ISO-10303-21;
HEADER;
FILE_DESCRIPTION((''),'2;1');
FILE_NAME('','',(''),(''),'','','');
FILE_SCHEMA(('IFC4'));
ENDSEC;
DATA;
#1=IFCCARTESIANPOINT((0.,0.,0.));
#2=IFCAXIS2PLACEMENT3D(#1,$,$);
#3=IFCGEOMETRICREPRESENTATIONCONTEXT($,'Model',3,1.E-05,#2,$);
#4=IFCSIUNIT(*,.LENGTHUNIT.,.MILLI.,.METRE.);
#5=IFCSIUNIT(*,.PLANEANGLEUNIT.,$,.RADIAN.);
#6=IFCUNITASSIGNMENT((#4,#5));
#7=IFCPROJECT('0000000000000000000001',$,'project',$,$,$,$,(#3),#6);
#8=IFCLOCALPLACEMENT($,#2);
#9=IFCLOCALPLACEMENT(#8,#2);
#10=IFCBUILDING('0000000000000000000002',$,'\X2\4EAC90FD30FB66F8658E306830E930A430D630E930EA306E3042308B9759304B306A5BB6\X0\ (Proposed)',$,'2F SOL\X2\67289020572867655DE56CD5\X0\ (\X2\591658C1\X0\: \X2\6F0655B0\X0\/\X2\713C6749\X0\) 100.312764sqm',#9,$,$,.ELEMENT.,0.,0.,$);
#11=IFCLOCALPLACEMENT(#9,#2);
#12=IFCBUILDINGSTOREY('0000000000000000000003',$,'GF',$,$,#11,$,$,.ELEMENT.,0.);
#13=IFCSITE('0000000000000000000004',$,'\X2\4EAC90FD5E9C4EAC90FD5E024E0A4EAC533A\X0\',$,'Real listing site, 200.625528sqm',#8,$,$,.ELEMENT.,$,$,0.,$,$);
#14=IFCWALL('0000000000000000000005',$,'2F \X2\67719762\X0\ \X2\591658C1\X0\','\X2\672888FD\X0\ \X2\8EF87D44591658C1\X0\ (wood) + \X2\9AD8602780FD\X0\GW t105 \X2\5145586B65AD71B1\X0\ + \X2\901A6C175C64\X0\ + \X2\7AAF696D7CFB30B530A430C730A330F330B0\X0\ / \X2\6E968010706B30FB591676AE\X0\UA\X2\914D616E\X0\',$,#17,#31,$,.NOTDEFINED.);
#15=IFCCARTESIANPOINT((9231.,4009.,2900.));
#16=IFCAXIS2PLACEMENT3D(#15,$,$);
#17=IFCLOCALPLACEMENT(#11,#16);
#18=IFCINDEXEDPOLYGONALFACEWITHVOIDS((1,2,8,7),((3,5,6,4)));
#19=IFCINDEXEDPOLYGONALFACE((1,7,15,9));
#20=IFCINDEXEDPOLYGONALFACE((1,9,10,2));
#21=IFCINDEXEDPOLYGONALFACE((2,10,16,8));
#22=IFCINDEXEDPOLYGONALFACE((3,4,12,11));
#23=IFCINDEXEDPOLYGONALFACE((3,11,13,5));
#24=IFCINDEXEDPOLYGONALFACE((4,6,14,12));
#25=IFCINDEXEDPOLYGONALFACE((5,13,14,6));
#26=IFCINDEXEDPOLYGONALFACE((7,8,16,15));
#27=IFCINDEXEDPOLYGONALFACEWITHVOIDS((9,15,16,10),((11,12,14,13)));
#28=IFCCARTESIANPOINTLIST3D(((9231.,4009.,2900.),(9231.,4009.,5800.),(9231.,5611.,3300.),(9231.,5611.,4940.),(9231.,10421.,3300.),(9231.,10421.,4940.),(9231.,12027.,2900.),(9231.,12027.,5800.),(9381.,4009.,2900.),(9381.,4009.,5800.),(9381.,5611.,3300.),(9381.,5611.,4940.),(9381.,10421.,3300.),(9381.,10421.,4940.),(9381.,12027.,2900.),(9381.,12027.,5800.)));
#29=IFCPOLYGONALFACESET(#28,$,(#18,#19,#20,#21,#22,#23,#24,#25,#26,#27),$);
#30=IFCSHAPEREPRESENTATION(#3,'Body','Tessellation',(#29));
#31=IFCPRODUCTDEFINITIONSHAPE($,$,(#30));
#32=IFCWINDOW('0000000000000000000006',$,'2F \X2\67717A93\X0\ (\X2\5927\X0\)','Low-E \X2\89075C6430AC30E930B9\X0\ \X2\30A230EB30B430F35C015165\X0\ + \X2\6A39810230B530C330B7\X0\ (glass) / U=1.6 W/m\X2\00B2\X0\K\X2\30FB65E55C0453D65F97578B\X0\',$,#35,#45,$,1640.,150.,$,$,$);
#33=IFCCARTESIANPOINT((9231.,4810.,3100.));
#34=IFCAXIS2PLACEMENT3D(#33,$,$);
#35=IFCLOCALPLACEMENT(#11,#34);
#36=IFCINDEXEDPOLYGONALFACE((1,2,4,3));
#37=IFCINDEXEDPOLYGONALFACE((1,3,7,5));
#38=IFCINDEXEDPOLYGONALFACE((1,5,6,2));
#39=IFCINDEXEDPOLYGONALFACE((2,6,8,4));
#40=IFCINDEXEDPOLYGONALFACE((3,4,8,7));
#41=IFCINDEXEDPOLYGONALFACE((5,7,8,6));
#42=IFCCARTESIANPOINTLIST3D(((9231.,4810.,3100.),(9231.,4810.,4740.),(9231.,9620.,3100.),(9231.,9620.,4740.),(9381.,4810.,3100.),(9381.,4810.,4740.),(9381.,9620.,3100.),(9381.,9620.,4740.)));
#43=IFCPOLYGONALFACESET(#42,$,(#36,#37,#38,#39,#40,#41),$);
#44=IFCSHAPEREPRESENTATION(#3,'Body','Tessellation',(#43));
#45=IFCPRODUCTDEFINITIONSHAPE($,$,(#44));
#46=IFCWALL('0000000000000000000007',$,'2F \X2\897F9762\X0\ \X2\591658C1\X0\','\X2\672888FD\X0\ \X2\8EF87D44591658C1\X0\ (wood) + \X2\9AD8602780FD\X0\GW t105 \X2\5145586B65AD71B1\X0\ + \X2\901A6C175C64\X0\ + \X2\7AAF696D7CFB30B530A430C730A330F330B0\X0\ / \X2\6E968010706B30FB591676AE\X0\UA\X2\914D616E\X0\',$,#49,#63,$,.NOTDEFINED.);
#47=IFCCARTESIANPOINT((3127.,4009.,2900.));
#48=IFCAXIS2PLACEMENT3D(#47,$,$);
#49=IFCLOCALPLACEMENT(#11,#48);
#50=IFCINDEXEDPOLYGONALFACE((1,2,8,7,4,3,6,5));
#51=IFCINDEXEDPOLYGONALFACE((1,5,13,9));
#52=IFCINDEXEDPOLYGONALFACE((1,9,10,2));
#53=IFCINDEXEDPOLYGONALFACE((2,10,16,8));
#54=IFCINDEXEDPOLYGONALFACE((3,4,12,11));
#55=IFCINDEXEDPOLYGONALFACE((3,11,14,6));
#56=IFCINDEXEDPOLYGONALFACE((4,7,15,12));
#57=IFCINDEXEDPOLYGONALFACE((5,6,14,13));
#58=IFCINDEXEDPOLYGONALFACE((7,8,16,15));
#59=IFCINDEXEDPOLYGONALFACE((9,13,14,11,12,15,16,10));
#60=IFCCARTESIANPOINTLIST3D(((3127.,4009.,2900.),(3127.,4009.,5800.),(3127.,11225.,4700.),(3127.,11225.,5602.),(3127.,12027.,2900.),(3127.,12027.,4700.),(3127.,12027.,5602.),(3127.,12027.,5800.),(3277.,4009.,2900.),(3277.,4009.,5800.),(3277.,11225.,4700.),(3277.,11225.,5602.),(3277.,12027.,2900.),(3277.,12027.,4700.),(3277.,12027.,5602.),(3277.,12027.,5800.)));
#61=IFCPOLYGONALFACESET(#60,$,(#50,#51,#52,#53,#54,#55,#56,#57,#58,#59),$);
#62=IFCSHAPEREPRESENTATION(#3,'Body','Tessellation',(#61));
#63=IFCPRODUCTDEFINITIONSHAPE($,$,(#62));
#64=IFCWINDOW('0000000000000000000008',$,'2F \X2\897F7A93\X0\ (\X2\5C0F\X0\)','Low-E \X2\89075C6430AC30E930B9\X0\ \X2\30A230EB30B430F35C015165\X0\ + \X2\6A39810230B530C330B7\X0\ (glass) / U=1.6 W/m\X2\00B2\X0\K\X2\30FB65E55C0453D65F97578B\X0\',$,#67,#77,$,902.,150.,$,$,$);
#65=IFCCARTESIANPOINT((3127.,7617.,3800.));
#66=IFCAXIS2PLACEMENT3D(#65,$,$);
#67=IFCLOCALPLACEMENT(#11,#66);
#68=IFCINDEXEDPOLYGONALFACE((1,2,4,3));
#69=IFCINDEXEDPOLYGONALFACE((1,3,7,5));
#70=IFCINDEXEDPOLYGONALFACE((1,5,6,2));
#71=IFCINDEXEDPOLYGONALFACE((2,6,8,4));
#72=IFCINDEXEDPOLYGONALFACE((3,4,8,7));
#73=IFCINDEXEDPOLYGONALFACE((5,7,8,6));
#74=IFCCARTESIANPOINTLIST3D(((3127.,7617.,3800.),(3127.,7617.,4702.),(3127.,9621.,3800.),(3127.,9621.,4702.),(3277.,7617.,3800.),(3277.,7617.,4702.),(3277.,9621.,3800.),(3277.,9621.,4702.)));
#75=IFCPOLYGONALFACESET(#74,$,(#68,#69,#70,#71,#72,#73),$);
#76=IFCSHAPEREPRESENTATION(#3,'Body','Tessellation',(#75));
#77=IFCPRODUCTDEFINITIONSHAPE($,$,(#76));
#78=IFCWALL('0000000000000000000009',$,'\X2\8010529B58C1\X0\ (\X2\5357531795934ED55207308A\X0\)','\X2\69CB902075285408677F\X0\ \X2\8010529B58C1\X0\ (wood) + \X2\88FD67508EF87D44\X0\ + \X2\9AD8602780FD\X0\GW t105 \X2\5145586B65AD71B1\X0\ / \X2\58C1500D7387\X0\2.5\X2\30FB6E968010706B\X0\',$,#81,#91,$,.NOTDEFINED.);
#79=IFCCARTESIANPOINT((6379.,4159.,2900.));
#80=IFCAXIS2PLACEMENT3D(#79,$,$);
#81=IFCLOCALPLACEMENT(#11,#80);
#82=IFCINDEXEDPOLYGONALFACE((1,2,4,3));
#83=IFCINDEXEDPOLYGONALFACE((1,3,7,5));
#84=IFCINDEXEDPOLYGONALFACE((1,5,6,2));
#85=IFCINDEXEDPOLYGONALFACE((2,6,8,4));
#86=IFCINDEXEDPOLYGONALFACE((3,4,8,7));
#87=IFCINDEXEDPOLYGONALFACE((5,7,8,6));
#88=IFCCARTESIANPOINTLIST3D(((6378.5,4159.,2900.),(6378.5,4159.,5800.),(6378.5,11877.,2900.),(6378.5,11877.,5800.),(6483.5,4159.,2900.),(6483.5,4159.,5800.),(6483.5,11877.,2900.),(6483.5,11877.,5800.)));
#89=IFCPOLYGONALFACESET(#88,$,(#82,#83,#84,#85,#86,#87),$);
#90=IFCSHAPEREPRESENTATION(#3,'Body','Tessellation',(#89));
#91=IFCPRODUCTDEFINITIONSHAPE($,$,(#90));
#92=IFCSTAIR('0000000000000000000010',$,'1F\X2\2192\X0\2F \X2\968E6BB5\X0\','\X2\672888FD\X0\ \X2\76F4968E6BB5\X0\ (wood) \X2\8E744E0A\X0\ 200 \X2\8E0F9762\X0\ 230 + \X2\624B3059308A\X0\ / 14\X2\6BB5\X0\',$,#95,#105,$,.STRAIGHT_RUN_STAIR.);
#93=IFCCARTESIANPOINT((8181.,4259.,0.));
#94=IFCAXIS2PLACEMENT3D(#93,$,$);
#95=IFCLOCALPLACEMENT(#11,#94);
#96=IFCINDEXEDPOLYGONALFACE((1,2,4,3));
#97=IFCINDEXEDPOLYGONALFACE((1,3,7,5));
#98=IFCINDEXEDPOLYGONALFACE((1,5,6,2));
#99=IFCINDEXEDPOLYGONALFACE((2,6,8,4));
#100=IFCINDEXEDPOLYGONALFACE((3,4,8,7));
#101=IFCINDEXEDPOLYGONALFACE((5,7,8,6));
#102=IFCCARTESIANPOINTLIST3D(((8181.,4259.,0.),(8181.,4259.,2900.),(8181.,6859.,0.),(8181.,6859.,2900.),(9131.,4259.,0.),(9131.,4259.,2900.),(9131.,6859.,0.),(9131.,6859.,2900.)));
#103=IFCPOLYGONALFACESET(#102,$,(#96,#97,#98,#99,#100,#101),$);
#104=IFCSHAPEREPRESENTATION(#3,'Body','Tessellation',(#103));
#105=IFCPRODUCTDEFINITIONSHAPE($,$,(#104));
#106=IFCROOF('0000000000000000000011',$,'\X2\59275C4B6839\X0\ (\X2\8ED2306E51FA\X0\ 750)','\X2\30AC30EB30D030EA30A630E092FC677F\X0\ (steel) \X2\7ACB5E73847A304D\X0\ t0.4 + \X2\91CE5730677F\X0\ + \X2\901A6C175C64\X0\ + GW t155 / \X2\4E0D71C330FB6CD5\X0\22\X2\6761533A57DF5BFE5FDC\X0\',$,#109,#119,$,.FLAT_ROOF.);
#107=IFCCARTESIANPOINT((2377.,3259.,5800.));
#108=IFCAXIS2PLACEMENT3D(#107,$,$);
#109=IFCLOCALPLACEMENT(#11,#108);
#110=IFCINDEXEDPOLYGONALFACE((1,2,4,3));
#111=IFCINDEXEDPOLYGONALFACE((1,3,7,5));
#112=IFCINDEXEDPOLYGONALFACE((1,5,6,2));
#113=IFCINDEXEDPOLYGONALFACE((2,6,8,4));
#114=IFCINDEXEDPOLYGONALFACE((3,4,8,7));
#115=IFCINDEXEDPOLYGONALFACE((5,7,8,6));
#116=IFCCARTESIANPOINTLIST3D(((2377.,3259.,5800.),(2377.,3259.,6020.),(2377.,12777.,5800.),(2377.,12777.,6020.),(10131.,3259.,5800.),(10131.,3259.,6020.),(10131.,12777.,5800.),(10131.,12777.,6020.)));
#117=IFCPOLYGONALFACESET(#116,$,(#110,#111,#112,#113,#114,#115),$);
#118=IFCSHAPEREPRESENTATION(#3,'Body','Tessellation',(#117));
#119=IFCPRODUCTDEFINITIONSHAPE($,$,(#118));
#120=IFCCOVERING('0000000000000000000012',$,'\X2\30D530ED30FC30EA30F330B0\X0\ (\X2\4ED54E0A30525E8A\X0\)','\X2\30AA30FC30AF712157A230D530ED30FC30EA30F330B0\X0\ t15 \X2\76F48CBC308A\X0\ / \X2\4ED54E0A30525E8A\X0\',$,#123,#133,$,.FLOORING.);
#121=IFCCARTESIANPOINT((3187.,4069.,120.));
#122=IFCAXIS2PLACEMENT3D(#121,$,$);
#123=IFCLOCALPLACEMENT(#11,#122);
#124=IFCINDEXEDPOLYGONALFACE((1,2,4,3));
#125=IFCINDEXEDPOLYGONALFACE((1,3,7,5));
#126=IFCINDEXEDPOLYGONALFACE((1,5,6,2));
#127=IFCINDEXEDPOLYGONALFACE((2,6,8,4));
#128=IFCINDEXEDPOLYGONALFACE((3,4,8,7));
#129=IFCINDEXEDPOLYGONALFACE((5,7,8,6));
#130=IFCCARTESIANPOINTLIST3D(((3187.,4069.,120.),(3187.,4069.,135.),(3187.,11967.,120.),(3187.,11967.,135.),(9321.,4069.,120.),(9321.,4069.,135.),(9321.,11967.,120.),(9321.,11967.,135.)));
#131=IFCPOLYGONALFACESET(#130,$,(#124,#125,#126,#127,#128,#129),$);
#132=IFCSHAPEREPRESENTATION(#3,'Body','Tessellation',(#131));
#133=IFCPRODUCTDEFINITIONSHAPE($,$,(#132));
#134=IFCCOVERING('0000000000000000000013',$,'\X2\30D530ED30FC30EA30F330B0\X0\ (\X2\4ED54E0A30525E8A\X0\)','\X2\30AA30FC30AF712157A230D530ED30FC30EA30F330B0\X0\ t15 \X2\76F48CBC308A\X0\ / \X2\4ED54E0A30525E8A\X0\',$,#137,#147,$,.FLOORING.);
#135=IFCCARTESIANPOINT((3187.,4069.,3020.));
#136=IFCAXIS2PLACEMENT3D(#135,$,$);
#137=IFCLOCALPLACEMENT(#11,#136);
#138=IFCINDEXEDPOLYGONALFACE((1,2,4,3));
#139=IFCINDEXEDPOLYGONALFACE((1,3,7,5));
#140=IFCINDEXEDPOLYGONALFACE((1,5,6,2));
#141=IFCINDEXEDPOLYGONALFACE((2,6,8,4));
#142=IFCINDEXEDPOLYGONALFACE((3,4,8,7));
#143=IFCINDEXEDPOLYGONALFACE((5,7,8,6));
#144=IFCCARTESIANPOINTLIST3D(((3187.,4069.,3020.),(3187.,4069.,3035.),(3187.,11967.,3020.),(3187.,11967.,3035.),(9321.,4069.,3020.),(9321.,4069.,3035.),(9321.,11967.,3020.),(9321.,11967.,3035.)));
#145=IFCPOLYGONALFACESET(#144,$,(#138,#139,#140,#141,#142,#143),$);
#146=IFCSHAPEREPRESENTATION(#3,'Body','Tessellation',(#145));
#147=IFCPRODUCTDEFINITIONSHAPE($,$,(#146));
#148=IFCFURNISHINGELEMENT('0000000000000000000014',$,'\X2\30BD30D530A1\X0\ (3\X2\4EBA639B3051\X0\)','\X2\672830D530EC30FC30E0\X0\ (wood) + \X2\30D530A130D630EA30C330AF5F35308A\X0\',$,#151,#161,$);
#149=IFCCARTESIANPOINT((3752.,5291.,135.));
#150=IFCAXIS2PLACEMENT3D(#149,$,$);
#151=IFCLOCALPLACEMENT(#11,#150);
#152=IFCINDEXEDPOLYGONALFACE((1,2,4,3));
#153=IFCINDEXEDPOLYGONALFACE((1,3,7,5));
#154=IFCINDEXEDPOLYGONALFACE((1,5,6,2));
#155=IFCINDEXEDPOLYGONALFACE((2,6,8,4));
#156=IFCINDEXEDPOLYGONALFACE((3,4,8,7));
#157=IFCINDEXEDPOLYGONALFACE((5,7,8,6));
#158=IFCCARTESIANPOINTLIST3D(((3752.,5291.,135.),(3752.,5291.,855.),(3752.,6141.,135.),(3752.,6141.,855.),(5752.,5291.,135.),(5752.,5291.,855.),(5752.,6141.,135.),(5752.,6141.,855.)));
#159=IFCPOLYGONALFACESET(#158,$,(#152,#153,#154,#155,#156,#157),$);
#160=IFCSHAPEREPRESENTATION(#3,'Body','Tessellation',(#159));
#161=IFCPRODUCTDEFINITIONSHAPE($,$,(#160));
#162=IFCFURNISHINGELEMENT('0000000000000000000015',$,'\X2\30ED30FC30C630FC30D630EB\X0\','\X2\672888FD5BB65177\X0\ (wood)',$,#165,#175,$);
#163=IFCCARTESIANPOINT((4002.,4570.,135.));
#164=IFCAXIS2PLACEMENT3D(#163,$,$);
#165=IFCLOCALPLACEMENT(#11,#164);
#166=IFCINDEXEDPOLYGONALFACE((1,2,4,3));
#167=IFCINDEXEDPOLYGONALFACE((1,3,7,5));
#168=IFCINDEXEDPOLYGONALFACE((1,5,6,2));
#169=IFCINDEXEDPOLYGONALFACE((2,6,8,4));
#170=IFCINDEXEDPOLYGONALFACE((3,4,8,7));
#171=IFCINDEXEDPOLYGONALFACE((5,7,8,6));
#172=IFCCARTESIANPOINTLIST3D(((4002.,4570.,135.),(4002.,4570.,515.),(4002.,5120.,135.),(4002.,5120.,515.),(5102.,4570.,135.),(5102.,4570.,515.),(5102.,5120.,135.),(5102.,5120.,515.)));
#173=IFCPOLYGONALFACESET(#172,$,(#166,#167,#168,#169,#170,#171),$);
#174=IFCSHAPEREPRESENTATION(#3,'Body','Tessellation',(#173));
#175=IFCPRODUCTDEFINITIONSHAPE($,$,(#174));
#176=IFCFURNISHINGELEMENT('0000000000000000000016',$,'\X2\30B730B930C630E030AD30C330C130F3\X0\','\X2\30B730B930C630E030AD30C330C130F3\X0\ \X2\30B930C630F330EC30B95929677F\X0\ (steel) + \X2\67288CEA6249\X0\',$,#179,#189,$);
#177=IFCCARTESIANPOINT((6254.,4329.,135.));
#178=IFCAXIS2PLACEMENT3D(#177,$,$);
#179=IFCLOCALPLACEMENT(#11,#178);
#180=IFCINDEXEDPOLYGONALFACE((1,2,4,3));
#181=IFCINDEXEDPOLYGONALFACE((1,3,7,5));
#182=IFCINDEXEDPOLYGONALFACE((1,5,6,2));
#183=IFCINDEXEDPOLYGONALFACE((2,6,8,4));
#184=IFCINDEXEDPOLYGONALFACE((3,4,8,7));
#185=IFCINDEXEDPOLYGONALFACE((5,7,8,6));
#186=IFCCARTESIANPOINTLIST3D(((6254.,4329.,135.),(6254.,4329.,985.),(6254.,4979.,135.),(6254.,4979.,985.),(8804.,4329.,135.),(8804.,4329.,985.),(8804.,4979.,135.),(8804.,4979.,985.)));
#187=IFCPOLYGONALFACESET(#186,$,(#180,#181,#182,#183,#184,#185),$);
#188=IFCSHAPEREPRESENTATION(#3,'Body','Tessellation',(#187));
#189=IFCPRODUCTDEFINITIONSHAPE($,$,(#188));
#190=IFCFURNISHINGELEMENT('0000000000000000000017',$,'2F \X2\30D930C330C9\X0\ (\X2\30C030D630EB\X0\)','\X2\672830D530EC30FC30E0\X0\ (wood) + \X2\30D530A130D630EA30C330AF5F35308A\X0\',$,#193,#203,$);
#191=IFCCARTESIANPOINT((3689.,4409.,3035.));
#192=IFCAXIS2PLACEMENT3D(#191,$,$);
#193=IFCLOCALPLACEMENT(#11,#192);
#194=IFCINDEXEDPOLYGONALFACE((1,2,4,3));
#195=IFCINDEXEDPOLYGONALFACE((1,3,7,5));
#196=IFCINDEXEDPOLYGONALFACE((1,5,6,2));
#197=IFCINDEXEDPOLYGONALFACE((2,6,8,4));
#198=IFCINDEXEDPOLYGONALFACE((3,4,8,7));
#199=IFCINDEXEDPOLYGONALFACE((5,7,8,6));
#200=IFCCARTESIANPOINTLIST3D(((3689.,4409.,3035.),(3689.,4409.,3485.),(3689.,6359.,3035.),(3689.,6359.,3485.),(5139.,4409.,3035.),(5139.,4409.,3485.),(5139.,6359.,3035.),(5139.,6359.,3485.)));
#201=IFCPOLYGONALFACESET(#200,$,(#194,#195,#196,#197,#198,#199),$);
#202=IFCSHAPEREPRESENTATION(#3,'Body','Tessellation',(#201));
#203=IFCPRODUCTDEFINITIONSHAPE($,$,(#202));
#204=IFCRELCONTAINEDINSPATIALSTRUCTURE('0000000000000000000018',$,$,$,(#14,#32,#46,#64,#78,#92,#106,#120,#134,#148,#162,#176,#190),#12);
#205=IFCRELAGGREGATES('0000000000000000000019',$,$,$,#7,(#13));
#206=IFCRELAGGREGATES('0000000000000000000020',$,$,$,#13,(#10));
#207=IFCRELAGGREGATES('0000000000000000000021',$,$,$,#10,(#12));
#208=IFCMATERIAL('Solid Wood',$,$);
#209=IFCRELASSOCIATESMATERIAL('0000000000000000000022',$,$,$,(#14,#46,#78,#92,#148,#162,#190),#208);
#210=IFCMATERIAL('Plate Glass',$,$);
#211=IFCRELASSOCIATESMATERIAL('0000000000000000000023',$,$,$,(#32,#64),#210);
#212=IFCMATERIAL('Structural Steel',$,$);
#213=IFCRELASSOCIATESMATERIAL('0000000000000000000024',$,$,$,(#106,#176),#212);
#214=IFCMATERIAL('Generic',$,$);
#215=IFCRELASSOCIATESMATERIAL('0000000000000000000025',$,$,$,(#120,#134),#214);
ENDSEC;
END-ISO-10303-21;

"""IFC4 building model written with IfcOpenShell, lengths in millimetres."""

from ifc_helpers import new_model, si_unit, frame, frame_2d, origin, place, context, project, spatial, rectangle, extrude, material, element, fill, save


model = new_model("IFC4")

# Units and contexts
model_context = context("Model", 3, precision=1e-05, world=origin())
ifc_project = project(units=[si_unit("LENGTHUNIT", "METRE", prefix="MILLI"), si_unit("PLANEANGLEUNIT", "RADIAN")], contexts=[model_context])

# Site, building, storey
site_placement = place(None, origin())
site = spatial("IfcSite", under=ifc_project, at=site_placement, Name="京都府京都市上京区", ObjectType="Real listing site, 200.625528sqm", CompositionType="ELEMENT", RefElevation=0.0)
building_placement = place(site_placement, origin())
building = spatial("IfcBuilding", under=site, at=building_placement, Name="京都・書斎とライブラリのある静かな家 (Proposed)", ObjectType="2F SOL木造在来工法 (外壁: 漆喰/焼杉) 100.312764sqm", CompositionType="ELEMENT", ElevationOfRefHeight=0.0, ElevationOfTerrain=0.0)
storey_placement = place(building_placement, origin())
storey = spatial("IfcBuildingStorey", under=building, at=storey_placement, Name="GF", CompositionType="ELEMENT", Elevation=0.0)

# Shared definitions
ifc_material_1 = material(Name="Solid Wood")

# Shared definitions
ifc_material_2 = material(Name="Plate Glass")

# Walls, openings, windows
wall_1_placement = place(storey_placement, frame((9231.0, 4009.0, 2900.0)))
wall_1 = element("IfcWall", 1, at=wall_1_placement, inside=storey, material=ifc_material_1, Name="2F 東面 外壁", Description="木製 軸組外壁 (wood) + 高性能GW t105 充填断熱 + 通気層 + 窯業系サイディング / 準耐火・外皮UA配慮", PredefinedType="NOTDEFINED", context=model_context, shape_type="SweptSolid", body=[
    extrude(rectangle(XDim=150.0, YDim=8018.0, at=frame_2d((75.0, 4009.0))), frame((9231.0, 4009.0, 2900.0)), (0.0, 0.0, 1.0), 2900.0),
])
opening_1_placement = place(storey_placement, frame((9231.0, 4810.0, 3100.0)))
opening_1 = element("IfcOpeningElement", 2, at=opening_1_placement, cuts=wall_1, PredefinedType="NOTDEFINED", context=model_context, shape_type="SweptSolid", body=[
    extrude(rectangle(XDim=150.0, YDim=4810.0, at=frame_2d((75.0, 2405.0))), frame((9231.0, 4810.0, 3100.0)), (0.0, 0.0, 1.0), 1640.0),
])
window_1_placement = place(storey_placement, frame((9231.0, 4810.0, 3100.0)))
window_1 = element("IfcWindow", 3, at=window_1_placement, inside=storey, material=ifc_material_2, Name="2F 東窓 (大)", Description="Low-E 複層ガラス アルゴン封入 + 樹脂サッシ (glass) / U=1.6 W/m²K・日射取得型", OverallHeight=1640.0, OverallWidth=150.0, context=model_context, shape_type="SweptSolid", body=[
    extrude(rectangle(XDim=150.0, YDim=4810.0, at=frame_2d((75.0, 2405.0))), frame((9231.0, 4810.0, 3100.0)), (0.0, 0.0, 1.0), 1640.0),
])
fill(opening_1, window_1)
wall_2_placement = place(storey_placement, frame((3127.0, 4009.0, 2900.0)))
wall_2 = element("IfcWall", 4, at=wall_2_placement, inside=storey, material=ifc_material_1, Name="2F 西面 外壁", Description="木製 軸組外壁 (wood) + 高性能GW t105 充填断熱 + 通気層 + 窯業系サイディング / 準耐火・外皮UA配慮", PredefinedType="NOTDEFINED", context=model_context, shape_type="SweptSolid", body=[
    extrude(rectangle(XDim=150.0, YDim=8018.0, at=frame_2d((75.0, 4009.0))), frame((3127.0, 4009.0, 2900.0)), (0.0, 0.0, 1.0), 2900.0),
])
opening_2_placement = place(storey_placement, frame((3127.0, 7617.0, 3800.0)))
opening_2 = element("IfcOpeningElement", 5, at=opening_2_placement, cuts=wall_2, PredefinedType="NOTDEFINED", context=model_context, shape_type="SweptSolid", body=[
    extrude(rectangle(XDim=150.0, YDim=2004.0, at=frame_2d((75.0, 1002.0))), frame((3127.0, 7617.0, 3800.0)), (0.0, 0.0, 1.0), 902.0),
])
window_2_placement = place(storey_placement, frame((3127.0, 7617.0, 3800.0)))
window_2 = element("IfcWindow", 6, at=window_2_placement, inside=storey, material=ifc_material_2, Name="2F 西窓 (小)", Description="Low-E 複層ガラス アルゴン封入 + 樹脂サッシ (glass) / U=1.6 W/m²K・日射取得型", OverallHeight=902.0, OverallWidth=150.0, context=model_context, shape_type="SweptSolid", body=[
    extrude(rectangle(XDim=150.0, YDim=2004.0, at=frame_2d((75.0, 1002.0))), frame((3127.0, 7617.0, 3800.0)), (0.0, 0.0, 1.0), 902.0),
])
fill(opening_2, window_2)

# Wall
wall_3_placement = place(storey_placement, frame((6379.0, 4159.0, 2900.0)))
element("IfcWall", 7, at=wall_3_placement, inside=storey, material=ifc_material_1, Name="耐力壁 (南北間仕切り)", Description="構造用合板 耐力壁 (wood) + 製材軸組 + 高性能GW t105 充填断熱 / 壁倍率2.5・準耐火", PredefinedType="NOTDEFINED", context=model_context, shape_type="SweptSolid", body=[
    extrude(rectangle(XDim=105.0, YDim=7718.0, at=frame_2d((52.0, 3859.0))), frame((6379.0, 4159.0, 2900.0)), (0.0, 0.0, 1.0), 2900.0),
])

# Stair
stair_placement = place(storey_placement, frame((8181.0, 4259.0, 0.0)))
element("IfcStair", 8, at=stair_placement, inside=storey, material=ifc_material_1, Name="1F→2F 階段", Description="木製 直階段 (wood) 蹴上 200 踏面 230 + 手すり / 14段", PredefinedType="STRAIGHT_RUN_STAIR", context=model_context, shape_type="SweptSolid", body=[
    extrude(rectangle(XDim=950.0, YDim=2600.0, at=frame_2d((475.0, 1300.0))), frame((8181.0, 4259.0, 0.0)), (0.0, 0.0, 1.0), 2900.0),
])

# Roof
ifc_material_3 = material(Name="Structural Steel")
roof_placement = place(storey_placement, frame((2377.0, 3259.0, 5800.0)))
element("IfcRoof", 9, at=roof_placement, inside=storey, material=ifc_material_3, Name="大屋根 (軒の出 750)", Description="ガルバリウム鋼板 (steel) 立平葺き t0.4 + 野地板 + 通気層 + GW t155 / 不燃・法22条区域対応", PredefinedType="FLAT_ROOF", context=model_context, shape_type="SweptSolid", body=[
    extrude(rectangle(XDim=7754.0, YDim=9518.0, at=frame_2d((3877.0, 4759.0))), frame((2377.0, 3259.0, 5800.0)), (0.0, 0.0, 1.0), 220.0),
])

# Coverings
ifc_material_4 = material(Name="Generic")
covering_1_placement = place(storey_placement, frame((3187.0, 4069.0, 120.0)))
element("IfcCovering", 10, at=covering_1_placement, inside=storey, material=ifc_material_4, Name="フローリング (仕上げ床)", Description="オーク無垢フローリング t15 直貼り / 仕上げ床", PredefinedType="FLOORING", context=model_context, shape_type="SweptSolid", body=[
    extrude(rectangle(XDim=6134.0, YDim=7898.0, at=frame_2d((3067.0, 3949.0))), frame((3187.0, 4069.0, 120.0)), (0.0, 0.0, 1.0), 15.0),
])
covering_2_placement = place(storey_placement, frame((3187.0, 4069.0, 3020.0)))
element("IfcCovering", 11, at=covering_2_placement, inside=storey, material=ifc_material_4, Name="フローリング (仕上げ床)", Description="オーク無垢フローリング t15 直貼り / 仕上げ床", PredefinedType="FLOORING", context=model_context, shape_type="SweptSolid", body=[
    extrude(rectangle(XDim=6134.0, YDim=7898.0, at=frame_2d((3067.0, 3949.0))), frame((3187.0, 4069.0, 3020.0)), (0.0, 0.0, 1.0), 15.0),
])

# Furnishing elements
furnishing_1_placement = place(storey_placement, frame((3752.0, 5291.0, 135.0)))
element("IfcFurnishingElement", 12, at=furnishing_1_placement, inside=storey, material=ifc_material_1, Name="ソファ (3人掛け)", Description="木フレーム (wood) + ファブリック張り", context=model_context, shape_type="SweptSolid", body=[
    extrude(rectangle(XDim=2000.0, YDim=850.0, at=frame_2d((1000.0, 425.0))), frame((3752.0, 5291.0, 135.0)), (0.0, 0.0, 1.0), 720.0),
])
furnishing_2_placement = place(storey_placement, frame((4002.0, 4570.0, 135.0)))
element("IfcFurnishingElement", 13, at=furnishing_2_placement, inside=storey, material=ifc_material_1, Name="ローテーブル", Description="木製家具 (wood)", context=model_context, shape_type="SweptSolid", body=[
    extrude(rectangle(XDim=1100.0, YDim=550.0, at=frame_2d((550.0, 275.0))), frame((4002.0, 4570.0, 135.0)), (0.0, 0.0, 1.0), 380.0),
])
furnishing_3_placement = place(storey_placement, frame((6254.0, 4329.0, 135.0)))
element("IfcFurnishingElement", 14, at=furnishing_3_placement, inside=storey, material=ifc_material_3, Name="システムキッチン", Description="システムキッチン ステンレス天板 (steel) + 木質扉", context=model_context, shape_type="SweptSolid", body=[
    extrude(rectangle(XDim=2550.0, YDim=650.0, at=frame_2d((1275.0, 325.0))), frame((6254.0, 4329.0, 135.0)), (0.0, 0.0, 1.0), 850.0),
])
furnishing_4_placement = place(storey_placement, frame((3689.0, 4409.0, 3035.0)))
element("IfcFurnishingElement", 15, at=furnishing_4_placement, inside=storey, material=ifc_material_1, Name="2F ベッド (ダブル)", Description="木フレーム (wood) + ファブリック張り", context=model_context, shape_type="SweptSolid", body=[
    extrude(rectangle(XDim=1450.0, YDim=1950.0, at=frame_2d((725.0, 975.0))), frame((3689.0, 4409.0, 3035.0)), (0.0, 0.0, 1.0), 450.0),
])

save(model, "model.ifc")
